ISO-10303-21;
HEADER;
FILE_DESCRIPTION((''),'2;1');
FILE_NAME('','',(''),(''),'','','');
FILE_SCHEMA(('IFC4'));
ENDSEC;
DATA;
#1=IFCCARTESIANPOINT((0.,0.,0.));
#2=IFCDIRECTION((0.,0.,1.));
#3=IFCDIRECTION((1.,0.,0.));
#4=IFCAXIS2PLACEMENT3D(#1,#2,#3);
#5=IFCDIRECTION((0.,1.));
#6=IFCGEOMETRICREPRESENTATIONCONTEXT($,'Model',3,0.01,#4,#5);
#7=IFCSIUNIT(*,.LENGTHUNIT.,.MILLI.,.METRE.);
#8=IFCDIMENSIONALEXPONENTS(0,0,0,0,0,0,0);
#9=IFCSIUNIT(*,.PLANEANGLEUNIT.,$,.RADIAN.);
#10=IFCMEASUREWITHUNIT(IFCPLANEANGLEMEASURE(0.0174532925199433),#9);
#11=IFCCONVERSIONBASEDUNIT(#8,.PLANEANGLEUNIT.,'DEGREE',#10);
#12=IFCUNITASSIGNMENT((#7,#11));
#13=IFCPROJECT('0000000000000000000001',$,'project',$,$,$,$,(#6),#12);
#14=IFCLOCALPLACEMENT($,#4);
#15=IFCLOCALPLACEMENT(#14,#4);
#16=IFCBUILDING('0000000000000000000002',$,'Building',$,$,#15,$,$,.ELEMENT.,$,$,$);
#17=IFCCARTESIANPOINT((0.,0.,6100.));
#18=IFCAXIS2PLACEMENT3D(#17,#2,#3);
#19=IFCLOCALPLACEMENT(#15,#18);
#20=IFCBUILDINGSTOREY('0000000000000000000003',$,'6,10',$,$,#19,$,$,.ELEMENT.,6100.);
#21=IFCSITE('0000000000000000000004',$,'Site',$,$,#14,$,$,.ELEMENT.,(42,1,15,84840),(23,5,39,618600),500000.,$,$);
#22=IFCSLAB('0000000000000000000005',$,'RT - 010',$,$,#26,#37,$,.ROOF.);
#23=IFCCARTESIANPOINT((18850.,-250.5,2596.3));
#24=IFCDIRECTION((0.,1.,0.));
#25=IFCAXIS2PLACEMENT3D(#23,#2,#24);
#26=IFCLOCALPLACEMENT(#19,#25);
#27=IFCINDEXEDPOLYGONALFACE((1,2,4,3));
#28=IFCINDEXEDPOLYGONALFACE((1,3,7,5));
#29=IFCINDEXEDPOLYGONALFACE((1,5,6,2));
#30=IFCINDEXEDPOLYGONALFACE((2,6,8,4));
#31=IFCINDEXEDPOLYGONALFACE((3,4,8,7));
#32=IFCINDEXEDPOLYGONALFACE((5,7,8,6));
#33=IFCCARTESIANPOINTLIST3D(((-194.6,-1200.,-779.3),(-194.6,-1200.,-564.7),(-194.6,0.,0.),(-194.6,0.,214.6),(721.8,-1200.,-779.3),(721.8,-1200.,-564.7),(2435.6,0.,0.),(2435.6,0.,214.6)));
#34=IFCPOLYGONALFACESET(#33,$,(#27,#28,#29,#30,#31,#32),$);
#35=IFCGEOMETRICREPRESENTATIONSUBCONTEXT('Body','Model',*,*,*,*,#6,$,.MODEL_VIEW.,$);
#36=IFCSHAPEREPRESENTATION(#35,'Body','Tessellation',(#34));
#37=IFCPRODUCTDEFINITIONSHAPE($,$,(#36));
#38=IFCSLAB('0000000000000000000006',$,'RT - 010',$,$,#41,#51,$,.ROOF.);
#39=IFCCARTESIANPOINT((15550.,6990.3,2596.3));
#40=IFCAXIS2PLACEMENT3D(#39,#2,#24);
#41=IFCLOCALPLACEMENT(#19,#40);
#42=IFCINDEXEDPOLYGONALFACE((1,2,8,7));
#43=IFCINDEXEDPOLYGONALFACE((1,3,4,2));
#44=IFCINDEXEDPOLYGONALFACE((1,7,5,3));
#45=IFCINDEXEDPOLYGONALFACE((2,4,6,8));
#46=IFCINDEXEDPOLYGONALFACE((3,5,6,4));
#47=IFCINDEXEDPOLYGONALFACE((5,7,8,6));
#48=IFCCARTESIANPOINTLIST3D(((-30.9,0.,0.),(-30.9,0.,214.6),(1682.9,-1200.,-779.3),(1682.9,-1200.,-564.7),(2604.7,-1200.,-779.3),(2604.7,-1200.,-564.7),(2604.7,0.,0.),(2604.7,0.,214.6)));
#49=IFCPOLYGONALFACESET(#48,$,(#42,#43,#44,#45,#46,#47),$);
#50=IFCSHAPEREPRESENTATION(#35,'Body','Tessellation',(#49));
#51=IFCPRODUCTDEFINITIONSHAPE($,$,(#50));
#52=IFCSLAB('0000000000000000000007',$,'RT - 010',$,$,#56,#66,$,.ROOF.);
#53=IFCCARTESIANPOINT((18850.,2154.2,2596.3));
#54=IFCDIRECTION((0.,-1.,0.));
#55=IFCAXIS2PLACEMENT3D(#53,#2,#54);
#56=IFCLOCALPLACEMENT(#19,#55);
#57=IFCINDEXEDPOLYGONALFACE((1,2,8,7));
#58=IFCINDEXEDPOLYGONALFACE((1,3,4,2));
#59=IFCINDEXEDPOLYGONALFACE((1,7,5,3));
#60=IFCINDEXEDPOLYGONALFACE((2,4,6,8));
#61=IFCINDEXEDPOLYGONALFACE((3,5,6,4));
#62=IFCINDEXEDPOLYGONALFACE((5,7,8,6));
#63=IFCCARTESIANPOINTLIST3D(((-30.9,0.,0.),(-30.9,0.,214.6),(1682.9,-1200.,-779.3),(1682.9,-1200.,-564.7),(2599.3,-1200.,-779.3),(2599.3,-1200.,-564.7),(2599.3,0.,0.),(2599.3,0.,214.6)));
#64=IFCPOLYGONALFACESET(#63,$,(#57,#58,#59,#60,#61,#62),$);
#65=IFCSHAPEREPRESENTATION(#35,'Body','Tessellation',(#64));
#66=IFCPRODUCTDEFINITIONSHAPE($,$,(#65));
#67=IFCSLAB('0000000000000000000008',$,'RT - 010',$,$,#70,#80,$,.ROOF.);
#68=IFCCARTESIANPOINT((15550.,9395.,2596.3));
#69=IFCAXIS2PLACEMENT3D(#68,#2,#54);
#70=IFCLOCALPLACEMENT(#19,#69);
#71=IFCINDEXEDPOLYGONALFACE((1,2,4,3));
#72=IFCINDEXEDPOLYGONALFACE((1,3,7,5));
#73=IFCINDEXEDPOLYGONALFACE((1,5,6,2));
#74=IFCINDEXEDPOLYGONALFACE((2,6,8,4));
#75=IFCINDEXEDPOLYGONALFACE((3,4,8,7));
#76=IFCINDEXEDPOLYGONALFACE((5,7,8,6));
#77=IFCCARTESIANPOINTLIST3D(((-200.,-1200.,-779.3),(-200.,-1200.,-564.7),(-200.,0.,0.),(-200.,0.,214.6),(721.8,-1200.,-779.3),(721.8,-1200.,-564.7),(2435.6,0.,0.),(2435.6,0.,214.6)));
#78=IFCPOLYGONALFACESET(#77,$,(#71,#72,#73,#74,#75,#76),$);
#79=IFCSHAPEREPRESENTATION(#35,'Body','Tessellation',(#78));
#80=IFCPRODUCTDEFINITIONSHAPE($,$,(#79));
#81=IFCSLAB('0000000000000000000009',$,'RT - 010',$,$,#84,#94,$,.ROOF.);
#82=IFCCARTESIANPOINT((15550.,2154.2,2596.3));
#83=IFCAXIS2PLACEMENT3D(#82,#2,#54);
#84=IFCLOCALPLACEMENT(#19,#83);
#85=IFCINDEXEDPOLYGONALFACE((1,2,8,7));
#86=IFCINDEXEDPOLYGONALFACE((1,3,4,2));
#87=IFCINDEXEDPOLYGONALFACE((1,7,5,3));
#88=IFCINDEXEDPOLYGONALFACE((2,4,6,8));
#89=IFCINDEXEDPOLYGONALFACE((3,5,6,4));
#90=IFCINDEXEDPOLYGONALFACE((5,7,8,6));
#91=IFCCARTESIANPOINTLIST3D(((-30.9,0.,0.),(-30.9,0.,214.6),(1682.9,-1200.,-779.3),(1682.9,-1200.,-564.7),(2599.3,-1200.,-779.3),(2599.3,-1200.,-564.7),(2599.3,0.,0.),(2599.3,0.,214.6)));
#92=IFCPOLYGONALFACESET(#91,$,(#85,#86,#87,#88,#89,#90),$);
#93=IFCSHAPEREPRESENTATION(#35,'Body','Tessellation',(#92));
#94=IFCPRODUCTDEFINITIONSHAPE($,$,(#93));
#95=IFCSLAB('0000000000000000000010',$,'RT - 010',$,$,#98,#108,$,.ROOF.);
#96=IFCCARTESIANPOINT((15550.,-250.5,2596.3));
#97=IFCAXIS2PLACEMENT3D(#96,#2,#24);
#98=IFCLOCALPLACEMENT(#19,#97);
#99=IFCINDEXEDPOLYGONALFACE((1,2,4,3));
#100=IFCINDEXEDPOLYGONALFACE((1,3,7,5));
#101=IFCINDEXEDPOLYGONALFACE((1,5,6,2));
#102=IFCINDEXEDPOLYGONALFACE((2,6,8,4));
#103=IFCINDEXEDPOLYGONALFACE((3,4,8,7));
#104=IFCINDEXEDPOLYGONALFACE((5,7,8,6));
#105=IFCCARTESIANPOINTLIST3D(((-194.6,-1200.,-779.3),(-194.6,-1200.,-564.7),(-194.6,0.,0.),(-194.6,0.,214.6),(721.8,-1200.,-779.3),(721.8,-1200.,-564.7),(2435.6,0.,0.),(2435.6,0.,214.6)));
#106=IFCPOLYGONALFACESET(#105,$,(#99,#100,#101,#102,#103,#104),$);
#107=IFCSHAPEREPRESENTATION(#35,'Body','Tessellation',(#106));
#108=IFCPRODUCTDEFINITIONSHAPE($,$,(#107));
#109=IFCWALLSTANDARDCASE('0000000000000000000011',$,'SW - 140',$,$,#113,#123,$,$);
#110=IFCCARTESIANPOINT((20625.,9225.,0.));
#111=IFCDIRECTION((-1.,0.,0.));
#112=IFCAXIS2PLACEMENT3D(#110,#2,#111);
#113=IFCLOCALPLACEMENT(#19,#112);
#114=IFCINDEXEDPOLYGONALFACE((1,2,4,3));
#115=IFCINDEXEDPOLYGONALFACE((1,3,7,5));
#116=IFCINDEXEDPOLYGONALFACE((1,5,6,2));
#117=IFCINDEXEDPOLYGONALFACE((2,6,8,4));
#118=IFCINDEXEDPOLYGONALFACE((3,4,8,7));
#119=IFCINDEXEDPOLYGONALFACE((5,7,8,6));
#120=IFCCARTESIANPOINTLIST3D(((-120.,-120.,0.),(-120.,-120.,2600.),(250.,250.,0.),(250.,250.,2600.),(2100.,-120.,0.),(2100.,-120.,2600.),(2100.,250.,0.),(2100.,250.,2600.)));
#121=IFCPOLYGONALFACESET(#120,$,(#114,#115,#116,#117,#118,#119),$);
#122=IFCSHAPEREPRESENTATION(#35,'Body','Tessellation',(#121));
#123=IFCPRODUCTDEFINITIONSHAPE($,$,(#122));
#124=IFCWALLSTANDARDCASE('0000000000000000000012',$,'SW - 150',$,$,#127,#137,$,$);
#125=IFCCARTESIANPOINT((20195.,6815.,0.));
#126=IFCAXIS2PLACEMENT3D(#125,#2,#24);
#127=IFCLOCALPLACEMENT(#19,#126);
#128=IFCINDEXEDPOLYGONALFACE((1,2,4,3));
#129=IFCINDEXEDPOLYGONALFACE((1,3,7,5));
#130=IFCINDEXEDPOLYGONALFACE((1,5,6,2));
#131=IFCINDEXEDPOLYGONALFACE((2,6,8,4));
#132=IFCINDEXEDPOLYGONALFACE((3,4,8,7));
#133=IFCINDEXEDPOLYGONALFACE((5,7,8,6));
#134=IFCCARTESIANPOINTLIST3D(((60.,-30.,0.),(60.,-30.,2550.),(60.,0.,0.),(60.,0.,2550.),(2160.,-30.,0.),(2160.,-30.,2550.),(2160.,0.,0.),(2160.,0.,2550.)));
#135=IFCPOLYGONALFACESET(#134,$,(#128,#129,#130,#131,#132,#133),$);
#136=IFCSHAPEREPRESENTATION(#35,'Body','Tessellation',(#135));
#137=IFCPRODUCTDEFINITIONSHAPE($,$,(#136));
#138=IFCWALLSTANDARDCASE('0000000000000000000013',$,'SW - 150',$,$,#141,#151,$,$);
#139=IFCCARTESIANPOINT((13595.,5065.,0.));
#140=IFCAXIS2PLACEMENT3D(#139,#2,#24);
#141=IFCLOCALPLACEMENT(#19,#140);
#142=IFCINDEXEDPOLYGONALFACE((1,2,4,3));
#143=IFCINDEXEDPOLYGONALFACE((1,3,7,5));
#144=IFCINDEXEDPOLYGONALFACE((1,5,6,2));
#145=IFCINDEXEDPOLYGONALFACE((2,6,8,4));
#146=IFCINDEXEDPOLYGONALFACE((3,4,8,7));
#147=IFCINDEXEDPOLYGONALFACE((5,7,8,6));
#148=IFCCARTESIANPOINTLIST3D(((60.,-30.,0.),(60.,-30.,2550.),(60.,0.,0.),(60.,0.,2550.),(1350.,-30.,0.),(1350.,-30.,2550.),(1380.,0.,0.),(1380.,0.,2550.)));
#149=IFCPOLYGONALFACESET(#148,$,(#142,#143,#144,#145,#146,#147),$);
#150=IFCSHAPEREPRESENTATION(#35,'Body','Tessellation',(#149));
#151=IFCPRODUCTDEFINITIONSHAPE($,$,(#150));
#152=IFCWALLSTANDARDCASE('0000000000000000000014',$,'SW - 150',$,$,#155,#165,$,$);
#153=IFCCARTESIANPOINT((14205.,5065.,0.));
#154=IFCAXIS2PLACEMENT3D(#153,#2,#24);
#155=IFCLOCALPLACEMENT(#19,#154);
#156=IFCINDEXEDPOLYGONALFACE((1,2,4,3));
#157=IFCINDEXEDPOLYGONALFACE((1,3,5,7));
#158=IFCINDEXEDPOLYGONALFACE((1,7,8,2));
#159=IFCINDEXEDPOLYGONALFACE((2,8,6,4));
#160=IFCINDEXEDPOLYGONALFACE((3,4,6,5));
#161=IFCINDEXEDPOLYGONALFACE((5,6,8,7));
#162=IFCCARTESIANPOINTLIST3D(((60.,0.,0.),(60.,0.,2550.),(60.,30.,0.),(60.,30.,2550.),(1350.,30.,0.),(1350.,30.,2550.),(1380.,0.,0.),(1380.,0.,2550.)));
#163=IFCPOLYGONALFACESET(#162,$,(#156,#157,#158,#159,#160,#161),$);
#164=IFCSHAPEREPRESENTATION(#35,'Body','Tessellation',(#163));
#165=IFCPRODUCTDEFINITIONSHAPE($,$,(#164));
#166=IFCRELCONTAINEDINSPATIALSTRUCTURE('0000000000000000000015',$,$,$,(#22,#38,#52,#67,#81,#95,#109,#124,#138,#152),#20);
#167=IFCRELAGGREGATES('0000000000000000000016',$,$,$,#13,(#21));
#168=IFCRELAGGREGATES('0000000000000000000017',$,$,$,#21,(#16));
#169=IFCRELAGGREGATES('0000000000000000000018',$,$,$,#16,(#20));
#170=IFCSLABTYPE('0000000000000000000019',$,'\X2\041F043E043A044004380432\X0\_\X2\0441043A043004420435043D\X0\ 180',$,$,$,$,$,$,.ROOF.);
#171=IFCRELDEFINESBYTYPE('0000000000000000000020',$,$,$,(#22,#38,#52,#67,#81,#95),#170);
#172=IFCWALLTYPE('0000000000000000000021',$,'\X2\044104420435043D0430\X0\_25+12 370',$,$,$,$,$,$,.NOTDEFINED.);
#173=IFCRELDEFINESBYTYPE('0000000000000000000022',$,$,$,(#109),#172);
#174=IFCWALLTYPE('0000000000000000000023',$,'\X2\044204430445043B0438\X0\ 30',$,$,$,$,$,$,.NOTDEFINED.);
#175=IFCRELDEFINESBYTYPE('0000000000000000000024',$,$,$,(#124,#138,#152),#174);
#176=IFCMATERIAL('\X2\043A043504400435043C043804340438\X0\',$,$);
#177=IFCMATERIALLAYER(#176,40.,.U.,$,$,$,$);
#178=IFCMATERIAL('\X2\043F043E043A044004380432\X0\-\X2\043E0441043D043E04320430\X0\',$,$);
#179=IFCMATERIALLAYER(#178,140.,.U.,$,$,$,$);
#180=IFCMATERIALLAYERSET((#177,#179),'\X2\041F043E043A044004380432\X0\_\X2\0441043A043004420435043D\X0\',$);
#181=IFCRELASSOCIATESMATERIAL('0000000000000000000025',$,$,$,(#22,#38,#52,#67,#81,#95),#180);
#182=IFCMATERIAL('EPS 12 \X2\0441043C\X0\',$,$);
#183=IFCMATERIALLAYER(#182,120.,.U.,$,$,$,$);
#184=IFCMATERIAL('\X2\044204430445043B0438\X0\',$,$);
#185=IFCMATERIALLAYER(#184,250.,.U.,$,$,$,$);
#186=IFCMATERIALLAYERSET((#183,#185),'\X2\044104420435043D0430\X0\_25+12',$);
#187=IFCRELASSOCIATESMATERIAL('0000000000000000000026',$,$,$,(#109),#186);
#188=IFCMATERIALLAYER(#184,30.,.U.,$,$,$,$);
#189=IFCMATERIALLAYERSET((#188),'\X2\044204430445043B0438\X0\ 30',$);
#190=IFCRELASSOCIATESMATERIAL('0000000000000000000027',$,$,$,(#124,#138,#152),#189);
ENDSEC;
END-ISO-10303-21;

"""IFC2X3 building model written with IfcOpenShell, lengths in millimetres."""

from ifc_helpers import new_model, entity, si_unit, converted_unit, direction, frame, origin_with_axes, place, context, subcontext, project, spatial, polyline, outline, extrude, material, layer, layer_set, layer_usage, type_object, element, save


model = new_model("IFC2X3")

# Units and contexts
model_context = context("Model", 3, precision=0.01, world=origin_with_axes(), true_north=direction((0.0, 1.0)))
body_context = subcontext(model_context, "Body", "Model", "MODEL_VIEW")
ifc_project = project(units=[si_unit("LENGTHUNIT", "METRE", prefix="MILLI"), converted_unit("PLANEANGLEUNIT", "DEGREE", entity("IfcPlaneAngleMeasure", 0.0174532925199433), si_unit("PLANEANGLEUNIT", "RADIAN"), dimensions=[0, 0, 0, 0, 0, 0, 0])], contexts=[model_context])

# Site, building, storey
site_placement = place(None, origin_with_axes())
site = spatial("IfcSite", under=ifc_project, at=site_placement, Name="Site", CompositionType="ELEMENT", RefLatitude=(42, 1, 15, 84840), RefLongitude=(23, 5, 39, 618600), RefElevation=500000.0)
building_placement = place(site_placement, origin_with_axes())
building = spatial("IfcBuilding", under=site, at=building_placement, Name="Building", CompositionType="ELEMENT")
storey_placement = place(building_placement, frame((0.0, 0.0, 6100.0), z_axis=(0.0, 0.0, 1.0), x_axis=(1.0, 0.0, 0.0)))
storey = spatial("IfcBuildingStorey", under=building, at=storey_placement, Name="6,10", CompositionType="ELEMENT", Elevation=6100.0)

# Slabs
ifc_material_1 = material(Name="керемиди")
ifc_layer_1 = layer(ifc_material_1, 40.0, ventilated="UNKNOWN")
ifc_material_2 = material(Name="покрив-основа")
ifc_layer_2 = layer(ifc_material_2, 140.0, ventilated="UNKNOWN")
ifc_layer_set_1 = layer_set([ifc_layer_1, ifc_layer_2], Name="Покрив_скатен")
ifc_layer_usage_1 = layer_usage(ifc_layer_set_1, "AXIS3", "NEGATIVE", 180.0)
slab_type = type_object("IfcSlabType", Name="Покрив_скатен 180", PredefinedType="ROOF")
slab_1_placement = place(storey_placement, frame((18850.0, -250.5, 2596.3), z_axis=(0.0, 0.0, 1.0), x_axis=(0.0, 1.0, 0.0)))
element("IfcSlab", 1, at=slab_1_placement, inside=storey, type_object=slab_type, material=ifc_layer_usage_1, Name="RT - 010", PredefinedType="ROOF", context=body_context, shape_type="SweptSolid", body=[
    extrude(outline(polyline([(2435.6, 0.0), (-194.6, 0.0), (-194.6, -1430.8), (721.8, -1430.8), (2435.6, 0.0)])), frame((0.0, 0.0, 0.0), z_axis=(0.0, -0.544639, 0.838671), x_axis=(1.0, 0.0, 0.0)), (0.0, 0.544639, 0.838671), 214.6),
])
ifc_layer_usage_2 = layer_usage(ifc_layer_set_1, "AXIS3", "NEGATIVE", 180.0)
slab_2_placement = place(storey_placement, frame((15550.0, 6990.3, 2596.3), z_axis=(0.0, 0.0, 1.0), x_axis=(0.0, 1.0, 0.0)))
element("IfcSlab", 2, at=slab_2_placement, inside=storey, type_object=slab_type, material=ifc_layer_usage_2, Name="RT - 010", PredefinedType="ROOF", context=body_context, shape_type="SweptSolid", body=[
    extrude(outline(polyline([(-30.9, 0.0), (1682.9, -1430.8), (2604.7, -1430.8), (2604.7, 0.0), (-30.9, 0.0)])), frame((0.0, 0.0, 0.0), z_axis=(0.0, -0.544639, 0.838671), x_axis=(1.0, 0.0, 0.0)), (0.0, 0.544639, 0.838671), 214.6),
])
ifc_layer_usage_3 = layer_usage(ifc_layer_set_1, "AXIS3", "NEGATIVE", 180.0)
slab_3_placement = place(storey_placement, frame((18850.0, 2154.2, 2596.3), z_axis=(0.0, 0.0, 1.0), x_axis=(0.0, -1.0, 0.0)))
element("IfcSlab", 3, at=slab_3_placement, inside=storey, type_object=slab_type, material=ifc_layer_usage_3, Name="RT - 010", PredefinedType="ROOF", context=body_context, shape_type="SweptSolid", body=[
    extrude(outline(polyline([(-30.9, 0.0), (1682.9, -1430.8), (2599.3, -1430.8), (2599.3, 0.0), (-30.9, 0.0)])), frame((0.0, 0.0, 0.0), z_axis=(0.0, -0.544639, 0.838671), x_axis=(1.0, 0.0, 0.0)), (0.0, 0.544639, 0.838671), 214.6),
])
ifc_layer_usage_4 = layer_usage(ifc_layer_set_1, "AXIS3", "NEGATIVE", 180.0)
slab_4_placement = place(storey_placement, frame((15550.0, 9395.0, 2596.3), z_axis=(0.0, 0.0, 1.0), x_axis=(0.0, -1.0, 0.0)))
element("IfcSlab", 4, at=slab_4_placement, inside=storey, type_object=slab_type, material=ifc_layer_usage_4, Name="RT - 010", PredefinedType="ROOF", context=body_context, shape_type="SweptSolid", body=[
    extrude(outline(polyline([(2435.6, 0.0), (-200.0, 0.0), (-200.0, -1430.8), (721.8, -1430.8), (2435.6, 0.0)])), frame((0.0, 0.0, 0.0), z_axis=(0.0, -0.544639, 0.838671), x_axis=(1.0, 0.0, 0.0)), (0.0, 0.544639, 0.838671), 214.6),
])
ifc_layer_usage_5 = layer_usage(ifc_layer_set_1, "AXIS3", "NEGATIVE", 180.0)
slab_5_placement = place(storey_placement, frame((15550.0, 2154.2, 2596.3), z_axis=(0.0, 0.0, 1.0), x_axis=(0.0, -1.0, 0.0)))
element("IfcSlab", 5, at=slab_5_placement, inside=storey, type_object=slab_type, material=ifc_layer_usage_5, Name="RT - 010", PredefinedType="ROOF", context=body_context, shape_type="SweptSolid", body=[
    extrude(outline(polyline([(-30.9, 0.0), (1682.9, -1430.8), (2599.3, -1430.8), (2599.3, 0.0), (-30.9, 0.0)])), frame((0.0, 0.0, 0.0), z_axis=(0.0, -0.544639, 0.838671), x_axis=(1.0, 0.0, 0.0)), (0.0, 0.544639, 0.838671), 214.6),
])
ifc_layer_usage_6 = layer_usage(ifc_layer_set_1, "AXIS3", "NEGATIVE", 180.0)
slab_6_placement = place(storey_placement, frame((15550.0, -250.5, 2596.3), z_axis=(0.0, 0.0, 1.0), x_axis=(0.0, 1.0, 0.0)))
element("IfcSlab", 6, at=slab_6_placement, inside=storey, type_object=slab_type, material=ifc_layer_usage_6, Name="RT - 010", PredefinedType="ROOF", context=body_context, shape_type="SweptSolid", body=[
    extrude(outline(polyline([(2435.6, 0.0), (-194.6, 0.0), (-194.6, -1430.8), (721.8, -1430.8), (2435.6, 0.0)])), frame((0.0, 0.0, 0.0), z_axis=(0.0, -0.544639, 0.838671), x_axis=(1.0, 0.0, 0.0)), (0.0, 0.544639, 0.838671), 214.6),
])

# Wall
ifc_material_3 = material(Name="EPS 12 см")
ifc_layer_3 = layer(ifc_material_3, 120.0, ventilated="UNKNOWN")
ifc_material_4 = material(Name="тухли")
ifc_layer_4 = layer(ifc_material_4, 250.0, ventilated="UNKNOWN")
ifc_layer_set_2 = layer_set([ifc_layer_3, ifc_layer_4], Name="стена_25+12")
wall_type_1 = type_object("IfcWallType", Name="стена_25+12 370", PredefinedType="NOTDEFINED")
ifc_layer_usage_7 = layer_usage(ifc_layer_set_2, "AXIS2", "POSITIVE", -120.0)
wall_1_placement = place(storey_placement, frame((20625.0, 9225.0, 0.0), z_axis=(0.0, 0.0, 1.0), x_axis=(-1.0, 0.0, 0.0)))
element("IfcWallStandardCase", 7, at=wall_1_placement, inside=storey, type_object=wall_type_1, material=ifc_layer_usage_7, Name="SW - 140", context=body_context, shape_type="SweptSolid", body=[
    extrude(outline(polyline([(-120.0, -120.0), (2100.0, -120.0), (2100.0, 250.0), (250.0, 250.0), (-120.0, -120.0)])), origin_with_axes(), (0.0, 0.0, 1.0), 2600.0),
])

# Walls
ifc_layer_5 = layer(ifc_material_4, 30.0, ventilated="UNKNOWN")
ifc_layer_set_3 = layer_set([ifc_layer_5], Name="тухли 30")
ifc_layer_usage_8 = layer_usage(ifc_layer_set_3, "AXIS2", "NEGATIVE", 0.0)
wall_type_2 = type_object("IfcWallType", Name="тухли 30", PredefinedType="NOTDEFINED")
wall_2_placement = place(storey_placement, frame((20195.0, 6815.0, 0.0), z_axis=(0.0, 0.0, 1.0), x_axis=(0.0, 1.0, 0.0)))
element("IfcWallStandardCase", 8, at=wall_2_placement, inside=storey, type_object=wall_type_2, material=ifc_layer_usage_8, Name="SW - 150", context=body_context, shape_type="SweptSolid", body=[
    extrude(outline(polyline([(60.0, -30.0), (2160.0, -30.0), (2160.0, 0.0), (60.0, 0.0), (60.0, -30.0)])), origin_with_axes(), (0.0, 0.0, 1.0), 2550.0),
])
ifc_layer_usage_9 = layer_usage(ifc_layer_set_3, "AXIS2", "NEGATIVE", 0.0)
wall_3_placement = place(storey_placement, frame((13595.0, 5065.0, 0.0), z_axis=(0.0, 0.0, 1.0), x_axis=(0.0, 1.0, 0.0)))
element("IfcWallStandardCase", 9, at=wall_3_placement, inside=storey, type_object=wall_type_2, material=ifc_layer_usage_9, Name="SW - 150", context=body_context, shape_type="SweptSolid", body=[
    extrude(outline(polyline([(60.0, -30.0), (1350.0, -30.0), (1380.0, 0.0), (60.0, 0.0), (60.0, -30.0)])), origin_with_axes(), (0.0, 0.0, 1.0), 2550.0),
])
ifc_layer_usage_10 = layer_usage(ifc_layer_set_3, "AXIS2", "POSITIVE", 0.0)
wall_4_placement = place(storey_placement, frame((14205.0, 5065.0, 0.0), z_axis=(0.0, 0.0, 1.0), x_axis=(0.0, 1.0, 0.0)))
element("IfcWallStandardCase", 10, at=wall_4_placement, inside=storey, type_object=wall_type_2, material=ifc_layer_usage_10, Name="SW - 150", context=body_context, shape_type="SweptSolid", body=[
    extrude(outline(polyline([(60.0, 0.0), (1380.0, 0.0), (1350.0, 30.0), (60.0, 30.0), (60.0, 0.0)])), origin_with_axes(), (0.0, 0.0, 1.0), 2550.0),
])

save(model, "model.ifc")
